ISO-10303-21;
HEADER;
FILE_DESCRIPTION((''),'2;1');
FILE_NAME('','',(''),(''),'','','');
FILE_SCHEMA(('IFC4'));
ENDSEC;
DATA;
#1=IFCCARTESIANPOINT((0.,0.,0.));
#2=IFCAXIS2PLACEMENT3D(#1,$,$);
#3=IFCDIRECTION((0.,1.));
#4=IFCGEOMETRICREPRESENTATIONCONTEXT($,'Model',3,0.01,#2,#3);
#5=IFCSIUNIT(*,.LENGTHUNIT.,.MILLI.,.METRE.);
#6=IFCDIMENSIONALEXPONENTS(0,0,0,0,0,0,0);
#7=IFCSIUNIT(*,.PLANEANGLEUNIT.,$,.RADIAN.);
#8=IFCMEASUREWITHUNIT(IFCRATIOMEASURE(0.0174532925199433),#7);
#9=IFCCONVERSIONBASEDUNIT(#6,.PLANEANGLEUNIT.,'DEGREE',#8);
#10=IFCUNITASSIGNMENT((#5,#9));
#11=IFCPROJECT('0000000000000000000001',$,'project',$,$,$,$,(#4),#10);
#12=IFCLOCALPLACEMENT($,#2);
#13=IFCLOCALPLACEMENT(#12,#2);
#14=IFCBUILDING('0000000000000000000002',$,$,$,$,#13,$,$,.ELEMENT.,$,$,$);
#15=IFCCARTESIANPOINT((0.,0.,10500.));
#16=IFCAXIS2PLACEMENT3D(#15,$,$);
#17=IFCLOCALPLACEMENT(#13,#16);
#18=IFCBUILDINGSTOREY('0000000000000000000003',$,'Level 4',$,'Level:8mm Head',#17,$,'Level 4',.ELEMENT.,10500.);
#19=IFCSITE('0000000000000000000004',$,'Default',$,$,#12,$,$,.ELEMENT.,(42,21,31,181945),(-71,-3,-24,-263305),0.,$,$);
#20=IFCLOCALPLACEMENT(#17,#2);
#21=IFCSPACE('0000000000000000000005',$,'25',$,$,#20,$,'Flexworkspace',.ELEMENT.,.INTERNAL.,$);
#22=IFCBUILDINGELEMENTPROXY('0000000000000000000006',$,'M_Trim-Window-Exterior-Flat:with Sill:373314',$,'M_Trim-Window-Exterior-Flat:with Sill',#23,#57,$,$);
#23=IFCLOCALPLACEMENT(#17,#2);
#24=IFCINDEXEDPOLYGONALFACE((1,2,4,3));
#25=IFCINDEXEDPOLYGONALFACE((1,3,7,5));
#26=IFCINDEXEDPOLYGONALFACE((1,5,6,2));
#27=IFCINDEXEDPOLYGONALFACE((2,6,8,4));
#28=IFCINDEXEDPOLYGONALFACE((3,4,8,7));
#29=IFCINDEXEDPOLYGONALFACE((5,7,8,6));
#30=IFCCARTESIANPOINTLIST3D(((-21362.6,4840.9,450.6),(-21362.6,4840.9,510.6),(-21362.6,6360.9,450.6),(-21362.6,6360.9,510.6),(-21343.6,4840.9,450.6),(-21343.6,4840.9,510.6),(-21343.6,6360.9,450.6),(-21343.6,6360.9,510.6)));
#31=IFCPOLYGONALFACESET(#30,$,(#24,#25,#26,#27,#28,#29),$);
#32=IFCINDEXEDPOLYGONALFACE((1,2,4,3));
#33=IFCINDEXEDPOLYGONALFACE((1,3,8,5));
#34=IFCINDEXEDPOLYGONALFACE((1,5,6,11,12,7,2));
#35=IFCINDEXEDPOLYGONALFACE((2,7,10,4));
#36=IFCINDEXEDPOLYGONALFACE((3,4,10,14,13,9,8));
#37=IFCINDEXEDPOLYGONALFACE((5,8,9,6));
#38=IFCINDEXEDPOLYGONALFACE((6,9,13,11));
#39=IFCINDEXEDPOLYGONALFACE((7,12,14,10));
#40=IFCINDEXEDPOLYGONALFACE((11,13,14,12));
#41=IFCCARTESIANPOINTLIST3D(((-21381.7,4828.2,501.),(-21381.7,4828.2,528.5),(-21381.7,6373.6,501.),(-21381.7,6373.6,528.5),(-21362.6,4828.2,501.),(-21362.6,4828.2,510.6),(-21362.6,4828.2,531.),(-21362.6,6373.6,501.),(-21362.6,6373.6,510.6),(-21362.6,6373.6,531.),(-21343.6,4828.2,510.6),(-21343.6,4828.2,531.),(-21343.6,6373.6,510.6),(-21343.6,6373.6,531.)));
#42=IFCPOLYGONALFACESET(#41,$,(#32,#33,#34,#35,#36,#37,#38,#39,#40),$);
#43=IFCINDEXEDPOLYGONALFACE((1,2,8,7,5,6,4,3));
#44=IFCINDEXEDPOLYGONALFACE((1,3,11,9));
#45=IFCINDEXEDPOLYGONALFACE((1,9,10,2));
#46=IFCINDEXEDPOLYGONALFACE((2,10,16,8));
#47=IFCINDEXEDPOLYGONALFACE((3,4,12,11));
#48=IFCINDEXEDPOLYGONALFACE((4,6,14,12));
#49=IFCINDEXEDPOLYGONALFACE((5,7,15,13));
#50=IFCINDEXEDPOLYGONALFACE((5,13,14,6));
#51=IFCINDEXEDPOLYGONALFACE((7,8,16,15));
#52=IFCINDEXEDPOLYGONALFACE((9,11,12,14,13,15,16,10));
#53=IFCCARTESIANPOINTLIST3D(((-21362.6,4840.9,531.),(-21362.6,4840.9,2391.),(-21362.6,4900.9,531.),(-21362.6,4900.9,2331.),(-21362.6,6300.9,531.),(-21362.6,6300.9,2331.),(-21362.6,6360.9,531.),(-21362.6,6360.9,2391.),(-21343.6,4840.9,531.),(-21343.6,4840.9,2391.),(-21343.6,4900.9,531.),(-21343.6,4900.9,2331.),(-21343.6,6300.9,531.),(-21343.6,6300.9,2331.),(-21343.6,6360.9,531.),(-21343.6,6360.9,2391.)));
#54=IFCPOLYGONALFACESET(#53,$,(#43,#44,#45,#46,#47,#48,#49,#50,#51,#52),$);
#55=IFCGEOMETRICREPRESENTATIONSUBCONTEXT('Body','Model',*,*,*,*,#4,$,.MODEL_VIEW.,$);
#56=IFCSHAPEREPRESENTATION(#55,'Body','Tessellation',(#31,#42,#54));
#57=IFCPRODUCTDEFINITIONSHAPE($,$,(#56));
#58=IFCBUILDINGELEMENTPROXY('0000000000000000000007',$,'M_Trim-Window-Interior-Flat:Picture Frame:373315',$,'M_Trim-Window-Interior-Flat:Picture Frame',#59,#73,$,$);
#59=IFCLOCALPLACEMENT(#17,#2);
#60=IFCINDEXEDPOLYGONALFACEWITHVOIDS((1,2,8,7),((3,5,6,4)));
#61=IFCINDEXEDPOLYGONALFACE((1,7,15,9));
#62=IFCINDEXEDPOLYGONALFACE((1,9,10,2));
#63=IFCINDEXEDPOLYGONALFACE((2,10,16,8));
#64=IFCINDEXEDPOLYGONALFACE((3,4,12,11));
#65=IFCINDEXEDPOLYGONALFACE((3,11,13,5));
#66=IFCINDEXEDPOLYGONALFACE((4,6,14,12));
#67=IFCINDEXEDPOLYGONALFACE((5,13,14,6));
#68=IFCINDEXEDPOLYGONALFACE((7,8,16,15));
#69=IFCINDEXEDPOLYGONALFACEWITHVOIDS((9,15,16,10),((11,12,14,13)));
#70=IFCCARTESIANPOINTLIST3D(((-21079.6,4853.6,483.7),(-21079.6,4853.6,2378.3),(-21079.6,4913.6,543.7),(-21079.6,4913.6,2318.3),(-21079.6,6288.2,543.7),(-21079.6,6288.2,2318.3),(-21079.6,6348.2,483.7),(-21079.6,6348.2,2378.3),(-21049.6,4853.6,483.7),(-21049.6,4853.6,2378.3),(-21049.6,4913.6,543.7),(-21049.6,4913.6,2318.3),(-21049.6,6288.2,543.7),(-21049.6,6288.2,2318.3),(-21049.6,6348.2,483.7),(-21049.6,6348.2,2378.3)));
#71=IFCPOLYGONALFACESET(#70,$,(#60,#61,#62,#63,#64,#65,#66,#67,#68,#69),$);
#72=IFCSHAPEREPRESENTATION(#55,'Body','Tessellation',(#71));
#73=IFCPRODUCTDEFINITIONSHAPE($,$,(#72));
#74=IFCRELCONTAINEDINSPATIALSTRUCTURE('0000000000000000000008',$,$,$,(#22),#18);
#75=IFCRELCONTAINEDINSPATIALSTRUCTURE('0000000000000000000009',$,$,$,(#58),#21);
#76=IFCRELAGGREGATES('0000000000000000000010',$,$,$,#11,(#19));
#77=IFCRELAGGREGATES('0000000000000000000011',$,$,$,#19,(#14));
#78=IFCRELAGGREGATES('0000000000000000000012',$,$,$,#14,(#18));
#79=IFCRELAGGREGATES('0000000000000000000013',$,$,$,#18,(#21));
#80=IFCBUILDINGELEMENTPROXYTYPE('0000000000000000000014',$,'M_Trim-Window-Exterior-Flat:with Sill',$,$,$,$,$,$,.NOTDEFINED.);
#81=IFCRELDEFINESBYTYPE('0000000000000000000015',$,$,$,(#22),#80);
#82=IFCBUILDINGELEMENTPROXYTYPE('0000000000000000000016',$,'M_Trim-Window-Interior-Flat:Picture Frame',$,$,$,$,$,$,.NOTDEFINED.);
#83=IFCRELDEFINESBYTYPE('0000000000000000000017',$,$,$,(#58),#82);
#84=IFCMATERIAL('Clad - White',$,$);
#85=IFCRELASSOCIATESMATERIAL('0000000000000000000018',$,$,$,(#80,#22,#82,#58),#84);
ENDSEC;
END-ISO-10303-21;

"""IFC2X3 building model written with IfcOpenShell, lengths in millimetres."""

from ifc_helpers import new_model, entity, si_unit, converted_unit, direction, frame, frame_2d, origin, place, context, subcontext, project, spatial, polyline, rectangle, outline, extrude, source, transform, mapped, material, type_object, type_shapes, element, save


model = new_model("IFC2X3")

# Units and contexts
model_context = context("Model", 3, precision=0.01, world=origin(), true_north=direction((0.0, 1.0)))
body_context = subcontext(model_context, "Body", "Model", "MODEL_VIEW")
ifc_project = project(units=[si_unit("LENGTHUNIT", "METRE", prefix="MILLI"), converted_unit("PLANEANGLEUNIT", "DEGREE", entity("IfcRatioMeasure", 0.0174532925199433), si_unit("PLANEANGLEUNIT", "RADIAN"), dimensions=[0, 0, 0, 0, 0, 0, 0])], contexts=[model_context])

# Site, building, storey
site_placement = place(None, frame((0.0, 0.0, 0.0)))
site = spatial("IfcSite", under=ifc_project, at=site_placement, Name="Default", CompositionType="ELEMENT", RefLatitude=(42, 21, 31, 181945), RefLongitude=(-71, -3, -24, -263305), RefElevation=0.0)
building_placement = place(site_placement, origin())
building = spatial("IfcBuilding", under=site, at=building_placement, CompositionType="ELEMENT")
storey_placement = place(building_placement, frame((0.0, 0.0, 10500.0)))
storey = spatial("IfcBuildingStorey", under=building, at=storey_placement, Name="Level 4", ObjectType="Level:8mm Head", LongName="Level 4", CompositionType="ELEMENT", Elevation=10500.0)

# Building element proxy
ifc_material_1 = material(Name="Clad - White")
building_element_proxy_type_1 = type_object("IfcBuildingElementProxyType", Name="M_Trim-Window-Exterior-Flat:with Sill", PredefinedType="NOTDEFINED", material=ifc_material_1)
shared_shape_1 = source(origin(), body_context, "Body", "SweptSolid", [
    extrude(rectangle(XDim=1520.0, YDim=60.0, at=frame_2d((0.0, 0.0), x_axis=(1.0, 0.0))), frame((0.0, -1850.4, 0.0), z_axis=(0.0, 0.0, 1.0), x_axis=(-1.0, 0.0, 0.0)), (0.0, 0.0, 1.0), 19.1),
    extrude(outline(polyline([(-19.0, -15.2), (0.0, -15.2), (0.0, -5.7), (19.0, -5.7), (19.0, 14.8), (0.0, 14.8), (-19.0, 12.3), (-19.0, -15.2)])), frame((-772.7, -1814.8, 19.0), z_axis=(1.0, 0.0, 0.0), x_axis=(0.0, 0.0, -1.0)), (0.0, 0.0, 1.0), 1545.4),
    extrude(outline(polyline([(-945.0, -760.0), (915.0, -760.0), (915.0, -700.0), (-885.0, -700.0), (-885.0, 700.0), (915.0, 700.0), (915.0, 760.0), (-945.0, 760.0), (-945.0, -760.0)])), frame((0.0, -885.0, 0.0), z_axis=(0.0, 0.0, 1.0), x_axis=(0.0, -1.0, 0.0)), (0.0, 0.0, 1.0), 19.1),
])
type_shapes(building_element_proxy_type_1, [shared_shape_1])
proxy_1_placement = place(storey_placement, frame((-21343.6, 5600.9, 2331.0), z_axis=(-1.0, 0.0, 0.0), x_axis=(0.0, -1.0, 0.0)))
element("IfcBuildingElementProxy", 1, at=proxy_1_placement, inside=storey, type_object=building_element_proxy_type_1, material=ifc_material_1, Name="M_Trim-Window-Exterior-Flat:with Sill:373314", ObjectType="M_Trim-Window-Exterior-Flat:with Sill", context=body_context, shape_type="MappedRepresentation", body=[
    mapped(shared_shape_1, transform((0.0, 0.0, 0.0), scale=1.0)),
])

# Shared definitions
space_placement = place(storey_placement, origin())
space = spatial("IfcSpace", under=storey, at=space_placement, Name="25", LongName="Flexworkspace", CompositionType="ELEMENT", InteriorOrExteriorSpace="INTERNAL")

# Building element proxy
building_element_proxy_type_2 = type_object("IfcBuildingElementProxyType", Name="M_Trim-Window-Interior-Flat:Picture Frame", PredefinedType="NOTDEFINED", material=ifc_material_1)
shared_shape_2 = source(origin(), body_context, "Body", "SweptSolid", [
    extrude(outline(polyline([(-747.3, -947.3), (747.3, -947.3), (747.3, 947.3), (-747.3, 947.3), (-747.3, -947.3)]), holes=[polyline([(-687.3, -887.3), (-687.3, 887.3), (687.3, 887.3), (687.3, -887.3), (-687.3, -887.3)])]), frame((0.0, -900.0, 0.0), z_axis=(0.0, 0.0, 1.0), x_axis=(-1.0, 0.0, 0.0)), (0.0, 0.0, 1.0), 30.0),
])
type_shapes(building_element_proxy_type_2, [shared_shape_2])
proxy_2_placement = place(space_placement, frame((-21079.6, 5600.9, 2331.0), z_axis=(1.0, 0.0, 0.0), x_axis=(0.0, 1.0, 0.0)))
element("IfcBuildingElementProxy", 2, at=proxy_2_placement, inside=space, type_object=building_element_proxy_type_2, material=ifc_material_1, Name="M_Trim-Window-Interior-Flat:Picture Frame:373315", ObjectType="M_Trim-Window-Interior-Flat:Picture Frame", context=body_context, shape_type="MappedRepresentation", body=[
    mapped(shared_shape_2, transform((0.0, 0.0, 0.0), scale=1.0)),
])

save(model, "model.ifc")
